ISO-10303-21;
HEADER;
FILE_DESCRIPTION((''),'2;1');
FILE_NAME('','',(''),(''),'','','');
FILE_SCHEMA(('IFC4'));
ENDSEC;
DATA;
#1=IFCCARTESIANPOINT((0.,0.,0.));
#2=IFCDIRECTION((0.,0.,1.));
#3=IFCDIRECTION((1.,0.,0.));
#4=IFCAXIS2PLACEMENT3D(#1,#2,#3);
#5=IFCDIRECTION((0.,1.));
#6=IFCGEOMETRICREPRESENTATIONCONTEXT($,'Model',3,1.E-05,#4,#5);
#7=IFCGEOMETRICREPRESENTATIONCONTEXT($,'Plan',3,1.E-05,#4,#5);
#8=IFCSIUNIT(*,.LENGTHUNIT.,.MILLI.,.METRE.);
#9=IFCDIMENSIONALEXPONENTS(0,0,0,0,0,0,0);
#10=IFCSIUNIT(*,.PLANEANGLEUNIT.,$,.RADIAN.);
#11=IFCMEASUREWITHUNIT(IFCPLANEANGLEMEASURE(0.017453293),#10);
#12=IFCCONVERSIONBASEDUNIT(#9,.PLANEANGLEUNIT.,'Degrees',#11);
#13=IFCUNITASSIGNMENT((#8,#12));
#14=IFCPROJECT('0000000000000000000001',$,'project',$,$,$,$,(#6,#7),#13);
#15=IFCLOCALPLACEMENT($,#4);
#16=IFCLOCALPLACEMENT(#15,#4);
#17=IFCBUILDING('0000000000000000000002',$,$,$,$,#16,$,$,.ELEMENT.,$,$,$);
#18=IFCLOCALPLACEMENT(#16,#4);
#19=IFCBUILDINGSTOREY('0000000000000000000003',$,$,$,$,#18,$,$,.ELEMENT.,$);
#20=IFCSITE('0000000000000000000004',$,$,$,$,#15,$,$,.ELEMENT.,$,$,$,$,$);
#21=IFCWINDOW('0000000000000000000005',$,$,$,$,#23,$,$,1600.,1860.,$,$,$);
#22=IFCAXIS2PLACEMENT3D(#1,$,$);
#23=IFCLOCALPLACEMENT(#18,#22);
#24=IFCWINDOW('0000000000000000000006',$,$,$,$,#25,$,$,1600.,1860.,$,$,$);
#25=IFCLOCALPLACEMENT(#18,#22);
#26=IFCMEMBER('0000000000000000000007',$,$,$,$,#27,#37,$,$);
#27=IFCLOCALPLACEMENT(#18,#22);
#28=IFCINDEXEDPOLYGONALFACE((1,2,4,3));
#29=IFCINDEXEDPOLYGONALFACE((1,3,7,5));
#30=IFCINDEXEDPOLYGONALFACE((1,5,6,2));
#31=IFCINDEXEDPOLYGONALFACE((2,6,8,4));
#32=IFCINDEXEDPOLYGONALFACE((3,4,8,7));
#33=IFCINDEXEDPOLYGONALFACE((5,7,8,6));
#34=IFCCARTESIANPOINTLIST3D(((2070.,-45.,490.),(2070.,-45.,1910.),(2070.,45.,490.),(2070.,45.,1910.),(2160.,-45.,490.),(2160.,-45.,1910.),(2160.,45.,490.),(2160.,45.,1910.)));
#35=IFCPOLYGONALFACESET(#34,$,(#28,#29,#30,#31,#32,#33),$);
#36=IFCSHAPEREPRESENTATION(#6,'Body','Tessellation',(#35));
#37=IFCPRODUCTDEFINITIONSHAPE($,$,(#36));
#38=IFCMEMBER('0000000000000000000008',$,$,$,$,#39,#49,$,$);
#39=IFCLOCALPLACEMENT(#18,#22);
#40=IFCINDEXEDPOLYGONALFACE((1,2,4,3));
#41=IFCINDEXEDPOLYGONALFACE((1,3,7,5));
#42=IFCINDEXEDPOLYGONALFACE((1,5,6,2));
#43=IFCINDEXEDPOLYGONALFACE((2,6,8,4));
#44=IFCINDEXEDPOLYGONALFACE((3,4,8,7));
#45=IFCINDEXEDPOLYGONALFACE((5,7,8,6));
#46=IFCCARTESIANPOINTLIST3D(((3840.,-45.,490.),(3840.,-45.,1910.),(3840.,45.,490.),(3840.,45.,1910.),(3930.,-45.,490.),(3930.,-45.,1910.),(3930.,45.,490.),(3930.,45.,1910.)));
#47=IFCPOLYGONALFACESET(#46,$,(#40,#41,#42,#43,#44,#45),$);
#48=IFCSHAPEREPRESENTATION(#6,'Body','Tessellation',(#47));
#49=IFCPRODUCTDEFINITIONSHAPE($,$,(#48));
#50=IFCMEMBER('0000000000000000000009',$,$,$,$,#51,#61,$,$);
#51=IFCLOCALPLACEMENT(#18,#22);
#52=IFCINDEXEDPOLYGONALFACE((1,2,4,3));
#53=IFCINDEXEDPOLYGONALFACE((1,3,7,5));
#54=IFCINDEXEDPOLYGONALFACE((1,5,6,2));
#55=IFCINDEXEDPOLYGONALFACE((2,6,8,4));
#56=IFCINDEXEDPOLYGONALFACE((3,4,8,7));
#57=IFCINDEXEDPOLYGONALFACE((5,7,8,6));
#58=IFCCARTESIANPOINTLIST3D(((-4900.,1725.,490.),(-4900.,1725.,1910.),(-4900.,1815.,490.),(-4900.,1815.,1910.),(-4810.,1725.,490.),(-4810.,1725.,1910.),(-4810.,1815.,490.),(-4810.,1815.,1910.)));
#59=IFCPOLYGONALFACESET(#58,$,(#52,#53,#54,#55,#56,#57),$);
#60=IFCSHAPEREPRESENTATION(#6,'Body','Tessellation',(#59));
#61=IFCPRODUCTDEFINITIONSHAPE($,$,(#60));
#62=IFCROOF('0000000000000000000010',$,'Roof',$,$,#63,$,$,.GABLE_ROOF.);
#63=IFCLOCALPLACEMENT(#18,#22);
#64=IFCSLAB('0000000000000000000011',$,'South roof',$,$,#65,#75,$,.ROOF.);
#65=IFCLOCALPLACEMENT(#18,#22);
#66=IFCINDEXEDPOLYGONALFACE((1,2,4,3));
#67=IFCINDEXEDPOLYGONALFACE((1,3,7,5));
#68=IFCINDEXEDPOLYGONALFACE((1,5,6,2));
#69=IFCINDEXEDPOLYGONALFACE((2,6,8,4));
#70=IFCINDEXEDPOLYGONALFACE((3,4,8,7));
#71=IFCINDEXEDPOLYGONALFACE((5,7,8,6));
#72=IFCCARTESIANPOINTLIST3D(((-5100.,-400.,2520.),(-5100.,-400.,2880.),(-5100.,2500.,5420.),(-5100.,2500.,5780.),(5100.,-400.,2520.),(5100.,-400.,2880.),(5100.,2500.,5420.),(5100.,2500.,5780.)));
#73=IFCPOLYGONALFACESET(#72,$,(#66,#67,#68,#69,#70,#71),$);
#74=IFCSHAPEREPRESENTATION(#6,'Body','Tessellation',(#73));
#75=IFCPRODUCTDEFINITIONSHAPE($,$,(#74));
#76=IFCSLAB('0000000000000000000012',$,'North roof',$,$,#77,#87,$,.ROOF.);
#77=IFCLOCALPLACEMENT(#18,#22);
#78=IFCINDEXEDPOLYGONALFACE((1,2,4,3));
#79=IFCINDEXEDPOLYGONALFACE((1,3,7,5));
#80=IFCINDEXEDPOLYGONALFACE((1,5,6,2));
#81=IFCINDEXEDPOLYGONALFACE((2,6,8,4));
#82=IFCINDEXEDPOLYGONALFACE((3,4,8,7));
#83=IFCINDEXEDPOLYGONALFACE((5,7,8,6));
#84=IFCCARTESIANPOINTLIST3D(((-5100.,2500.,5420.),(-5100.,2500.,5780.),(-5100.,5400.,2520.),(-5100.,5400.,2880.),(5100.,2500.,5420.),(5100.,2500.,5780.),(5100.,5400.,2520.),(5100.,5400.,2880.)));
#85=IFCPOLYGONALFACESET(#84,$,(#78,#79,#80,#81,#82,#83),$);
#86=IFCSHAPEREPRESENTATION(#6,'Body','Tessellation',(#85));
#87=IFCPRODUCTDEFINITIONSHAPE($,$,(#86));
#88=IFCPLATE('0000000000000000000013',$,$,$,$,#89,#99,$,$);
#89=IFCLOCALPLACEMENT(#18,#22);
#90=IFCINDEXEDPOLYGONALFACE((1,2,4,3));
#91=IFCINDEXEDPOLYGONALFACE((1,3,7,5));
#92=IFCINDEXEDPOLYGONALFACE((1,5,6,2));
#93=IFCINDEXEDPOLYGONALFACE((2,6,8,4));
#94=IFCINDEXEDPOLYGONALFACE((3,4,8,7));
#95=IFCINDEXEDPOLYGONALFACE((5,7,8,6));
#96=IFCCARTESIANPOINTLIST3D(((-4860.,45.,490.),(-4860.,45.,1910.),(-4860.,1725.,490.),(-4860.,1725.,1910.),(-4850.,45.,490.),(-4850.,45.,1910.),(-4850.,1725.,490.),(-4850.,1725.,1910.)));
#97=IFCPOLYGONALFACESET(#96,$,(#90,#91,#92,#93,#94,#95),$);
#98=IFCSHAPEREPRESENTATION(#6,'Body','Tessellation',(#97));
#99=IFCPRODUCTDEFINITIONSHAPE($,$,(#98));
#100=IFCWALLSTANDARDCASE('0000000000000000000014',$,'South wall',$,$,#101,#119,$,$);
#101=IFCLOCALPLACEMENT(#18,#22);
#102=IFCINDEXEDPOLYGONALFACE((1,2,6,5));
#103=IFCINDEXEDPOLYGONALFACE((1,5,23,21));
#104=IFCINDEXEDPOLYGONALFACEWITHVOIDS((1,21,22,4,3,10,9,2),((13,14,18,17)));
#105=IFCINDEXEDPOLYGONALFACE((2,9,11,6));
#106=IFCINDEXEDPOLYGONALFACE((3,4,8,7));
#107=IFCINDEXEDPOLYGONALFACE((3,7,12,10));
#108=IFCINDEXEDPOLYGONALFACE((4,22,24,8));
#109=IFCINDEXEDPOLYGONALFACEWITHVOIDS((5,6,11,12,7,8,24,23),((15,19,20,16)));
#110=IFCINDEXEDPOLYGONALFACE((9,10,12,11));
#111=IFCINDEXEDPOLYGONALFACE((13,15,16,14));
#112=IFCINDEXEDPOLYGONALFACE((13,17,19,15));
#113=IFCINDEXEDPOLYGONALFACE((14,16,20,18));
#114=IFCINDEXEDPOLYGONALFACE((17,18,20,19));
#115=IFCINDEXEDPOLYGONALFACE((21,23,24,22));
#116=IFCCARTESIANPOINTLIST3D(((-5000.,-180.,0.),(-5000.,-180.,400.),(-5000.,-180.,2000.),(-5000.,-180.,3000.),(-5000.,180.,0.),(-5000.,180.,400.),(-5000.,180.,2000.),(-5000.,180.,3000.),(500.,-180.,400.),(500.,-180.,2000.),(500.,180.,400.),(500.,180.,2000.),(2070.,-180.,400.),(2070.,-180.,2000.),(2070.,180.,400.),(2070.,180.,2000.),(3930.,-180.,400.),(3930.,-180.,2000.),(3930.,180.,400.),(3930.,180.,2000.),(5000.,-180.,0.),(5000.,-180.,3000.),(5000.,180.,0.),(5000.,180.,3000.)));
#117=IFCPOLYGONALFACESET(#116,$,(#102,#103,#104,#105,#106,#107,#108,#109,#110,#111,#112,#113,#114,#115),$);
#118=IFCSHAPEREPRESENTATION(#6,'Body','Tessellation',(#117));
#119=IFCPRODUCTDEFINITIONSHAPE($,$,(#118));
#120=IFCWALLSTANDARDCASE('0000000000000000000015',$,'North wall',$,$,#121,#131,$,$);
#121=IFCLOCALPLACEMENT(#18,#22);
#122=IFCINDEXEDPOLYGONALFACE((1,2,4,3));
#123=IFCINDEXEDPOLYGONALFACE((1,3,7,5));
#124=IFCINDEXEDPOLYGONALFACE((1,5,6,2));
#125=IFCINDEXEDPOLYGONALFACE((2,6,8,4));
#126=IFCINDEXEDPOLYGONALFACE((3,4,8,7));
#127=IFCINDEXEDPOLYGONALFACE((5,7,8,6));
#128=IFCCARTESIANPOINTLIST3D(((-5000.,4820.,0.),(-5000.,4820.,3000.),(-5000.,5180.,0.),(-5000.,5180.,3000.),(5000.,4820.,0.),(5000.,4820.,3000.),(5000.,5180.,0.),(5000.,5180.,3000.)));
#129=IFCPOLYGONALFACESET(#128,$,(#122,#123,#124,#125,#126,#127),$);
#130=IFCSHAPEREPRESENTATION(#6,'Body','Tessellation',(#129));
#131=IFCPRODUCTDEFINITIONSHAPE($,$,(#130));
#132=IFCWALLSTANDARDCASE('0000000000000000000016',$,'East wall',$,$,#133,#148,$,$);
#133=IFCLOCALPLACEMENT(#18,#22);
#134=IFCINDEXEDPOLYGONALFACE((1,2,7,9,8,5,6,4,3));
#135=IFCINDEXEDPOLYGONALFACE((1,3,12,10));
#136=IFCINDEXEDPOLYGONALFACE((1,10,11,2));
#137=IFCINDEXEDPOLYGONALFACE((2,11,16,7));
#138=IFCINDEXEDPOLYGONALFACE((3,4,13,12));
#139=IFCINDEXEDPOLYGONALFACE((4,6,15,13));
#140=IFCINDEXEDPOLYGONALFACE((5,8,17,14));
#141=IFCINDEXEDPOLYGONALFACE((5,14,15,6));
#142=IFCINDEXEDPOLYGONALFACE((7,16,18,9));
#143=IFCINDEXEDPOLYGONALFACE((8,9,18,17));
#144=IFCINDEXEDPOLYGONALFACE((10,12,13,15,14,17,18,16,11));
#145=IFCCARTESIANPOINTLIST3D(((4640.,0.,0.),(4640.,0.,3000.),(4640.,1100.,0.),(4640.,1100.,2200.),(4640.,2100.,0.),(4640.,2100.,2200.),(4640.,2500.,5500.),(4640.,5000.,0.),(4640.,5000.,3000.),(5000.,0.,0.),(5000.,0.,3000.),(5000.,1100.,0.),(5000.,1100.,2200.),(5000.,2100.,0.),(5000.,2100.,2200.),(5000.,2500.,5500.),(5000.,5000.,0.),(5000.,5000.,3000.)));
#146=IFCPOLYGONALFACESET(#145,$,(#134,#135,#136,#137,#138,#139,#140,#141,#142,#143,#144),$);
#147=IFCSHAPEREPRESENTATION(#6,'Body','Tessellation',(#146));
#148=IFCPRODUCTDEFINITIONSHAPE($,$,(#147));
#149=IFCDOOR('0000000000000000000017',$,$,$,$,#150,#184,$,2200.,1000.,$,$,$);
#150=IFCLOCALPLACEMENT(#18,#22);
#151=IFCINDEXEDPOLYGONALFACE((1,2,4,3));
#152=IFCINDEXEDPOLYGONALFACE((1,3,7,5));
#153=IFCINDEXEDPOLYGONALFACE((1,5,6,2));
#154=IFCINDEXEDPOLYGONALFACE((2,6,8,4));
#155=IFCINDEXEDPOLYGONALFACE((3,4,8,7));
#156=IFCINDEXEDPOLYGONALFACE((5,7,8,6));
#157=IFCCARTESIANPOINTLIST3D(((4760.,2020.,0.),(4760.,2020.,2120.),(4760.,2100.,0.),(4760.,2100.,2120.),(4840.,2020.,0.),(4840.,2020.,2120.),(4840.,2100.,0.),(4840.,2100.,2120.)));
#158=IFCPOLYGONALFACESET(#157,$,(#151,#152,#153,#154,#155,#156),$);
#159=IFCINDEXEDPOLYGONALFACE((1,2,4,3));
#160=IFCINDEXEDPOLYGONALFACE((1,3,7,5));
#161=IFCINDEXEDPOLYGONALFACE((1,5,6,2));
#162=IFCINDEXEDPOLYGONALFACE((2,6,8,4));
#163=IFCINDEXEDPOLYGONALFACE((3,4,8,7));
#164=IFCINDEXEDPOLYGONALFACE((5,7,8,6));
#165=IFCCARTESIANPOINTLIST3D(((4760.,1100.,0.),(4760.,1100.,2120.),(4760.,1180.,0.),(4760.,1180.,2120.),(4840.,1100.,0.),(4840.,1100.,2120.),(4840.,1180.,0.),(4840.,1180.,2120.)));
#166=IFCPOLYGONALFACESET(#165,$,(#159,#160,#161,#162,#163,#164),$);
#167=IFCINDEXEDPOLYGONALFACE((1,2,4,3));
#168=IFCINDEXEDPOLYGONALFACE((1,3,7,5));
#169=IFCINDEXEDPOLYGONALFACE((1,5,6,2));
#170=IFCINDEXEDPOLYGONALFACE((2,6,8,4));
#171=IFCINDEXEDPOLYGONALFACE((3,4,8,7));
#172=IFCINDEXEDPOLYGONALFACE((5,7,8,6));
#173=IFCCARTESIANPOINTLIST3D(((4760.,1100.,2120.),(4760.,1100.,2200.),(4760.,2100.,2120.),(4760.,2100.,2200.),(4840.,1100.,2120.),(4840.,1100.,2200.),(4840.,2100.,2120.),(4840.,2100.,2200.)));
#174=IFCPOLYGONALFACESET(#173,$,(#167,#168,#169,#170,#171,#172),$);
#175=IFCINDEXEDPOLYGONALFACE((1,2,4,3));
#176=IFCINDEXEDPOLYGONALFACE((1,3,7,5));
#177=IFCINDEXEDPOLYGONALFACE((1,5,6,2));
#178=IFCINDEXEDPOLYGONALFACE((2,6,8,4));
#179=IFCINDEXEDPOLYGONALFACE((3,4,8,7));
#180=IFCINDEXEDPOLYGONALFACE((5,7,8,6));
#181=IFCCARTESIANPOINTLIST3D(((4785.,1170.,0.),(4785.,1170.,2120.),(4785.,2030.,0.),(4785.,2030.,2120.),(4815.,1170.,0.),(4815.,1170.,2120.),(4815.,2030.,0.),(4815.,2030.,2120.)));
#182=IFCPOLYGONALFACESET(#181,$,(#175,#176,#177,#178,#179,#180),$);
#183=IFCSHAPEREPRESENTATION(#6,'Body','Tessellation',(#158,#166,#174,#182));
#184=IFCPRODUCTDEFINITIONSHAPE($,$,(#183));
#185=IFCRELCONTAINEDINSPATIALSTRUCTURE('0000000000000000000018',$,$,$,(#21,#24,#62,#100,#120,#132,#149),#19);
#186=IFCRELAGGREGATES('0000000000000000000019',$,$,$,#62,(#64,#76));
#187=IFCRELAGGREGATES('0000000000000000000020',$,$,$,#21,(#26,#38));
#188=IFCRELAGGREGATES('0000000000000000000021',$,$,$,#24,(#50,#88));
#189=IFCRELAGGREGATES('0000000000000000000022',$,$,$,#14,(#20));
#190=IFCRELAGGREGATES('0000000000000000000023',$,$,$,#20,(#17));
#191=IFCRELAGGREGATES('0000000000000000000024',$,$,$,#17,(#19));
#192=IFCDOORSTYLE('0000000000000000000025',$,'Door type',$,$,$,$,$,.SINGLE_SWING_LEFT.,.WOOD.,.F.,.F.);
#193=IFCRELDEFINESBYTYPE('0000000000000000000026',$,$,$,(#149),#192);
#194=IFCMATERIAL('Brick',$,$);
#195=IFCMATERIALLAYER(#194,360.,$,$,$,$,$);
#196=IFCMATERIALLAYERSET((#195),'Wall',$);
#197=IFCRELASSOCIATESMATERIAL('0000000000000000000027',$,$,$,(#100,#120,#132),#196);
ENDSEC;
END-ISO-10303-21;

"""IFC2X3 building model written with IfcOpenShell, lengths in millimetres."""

from ifc_helpers import new_model, entity, si_unit, converted_unit, direction, frame, origin_with_axes, place, context, project, spatial, polyline, outline, extrude, clip, halfspace, source, transform, mapped, material, layer, layer_set, layer_usage, type_object, element, fill, aggregate, save


model = new_model("IFC2X3")

# Units and contexts
model_context = context("Model", 3, precision=1e-05, world=origin_with_axes(), true_north=direction((0.0, 1.0)))
plan_context = context("Plan", 3, precision=1e-05, world=origin_with_axes(), true_north=direction((0.0, 1.0)))
ifc_project = project(units=[si_unit("LENGTHUNIT", "METRE", prefix="MILLI"), converted_unit("PLANEANGLEUNIT", "Degrees", entity("IfcPlaneAngleMeasure", 0.017453293), si_unit("PLANEANGLEUNIT", "RADIAN"), dimensions=[0, 0, 0, 0, 0, 0, 0])], contexts=[model_context, plan_context])

# Site, building, storey
site_placement = place(None, origin_with_axes())
site = spatial("IfcSite", under=ifc_project, at=site_placement, CompositionType="ELEMENT")
building_placement = place(site_placement, origin_with_axes())
building = spatial("IfcBuilding", under=site, at=building_placement, CompositionType="ELEMENT")
storey_placement = place(building_placement, origin_with_axes())
storey = spatial("IfcBuildingStorey", under=building, at=storey_placement, CompositionType="ELEMENT")

# Windows
window_1_placement = place(storey_placement, frame((2070.0, -45.0, 400.0), z_axis=(0.0, 0.0, 1.0), x_axis=(1.0, 0.0, 0.0)))
window_1 = element("IfcWindow", 1, at=window_1_placement, inside=storey, OverallHeight=1600.0, OverallWidth=1860.0)
window_2_placement = place(storey_placement, frame((-4810.0, -45.0, 400.0), z_axis=(0.0, 0.0, 1.0), x_axis=(0.0, 1.0, 0.0)))
window_2 = element("IfcWindow", 2, at=window_2_placement, inside=storey, OverallHeight=1600.0, OverallWidth=1860.0)

# Members
shared_shape_1 = source(origin_with_axes(), model_context, "Body", "SweptSolid", [
    extrude(outline(polyline([(-45.0, -45.0), (45.0, -45.0), (45.0, 45.0), (-45.0, 45.0), (-45.0, -45.0)])), origin_with_axes(), (0.0, 0.0, 1.0), 1420.0),
])
member_1_placement = place(window_1_placement, frame((45.0, 45.0, 90.0), z_axis=(0.0, 0.0, 1.0), x_axis=(1.0, 0.0, 0.0)))
member_1 = element("IfcMember", 3, at=member_1_placement, context=model_context, shape_type="MappedRepresentation", body=[
    mapped(shared_shape_1, transform((0.0, 0.0, 0.0))),
])
member_2_placement = place(window_1_placement, frame((1815.0, 45.0, 90.0), z_axis=(0.0, 0.0, 1.0), x_axis=(1.0, 0.0, 0.0)))
member_2 = element("IfcMember", 4, at=member_2_placement, context=model_context, shape_type="MappedRepresentation", body=[
    mapped(shared_shape_1, transform((0.0, 0.0, 0.0))),
])
member_3_placement = place(window_2_placement, frame((1815.0, 45.0, 90.0), z_axis=(0.0, 0.0, 1.0), x_axis=(1.0, 0.0, 0.0)))
member_3 = element("IfcMember", 5, at=member_3_placement, context=model_context, shape_type="MappedRepresentation", body=[
    mapped(shared_shape_1, transform((0.0, 0.0, 0.0))),
])

# Roof, slabs
roof_placement = place(storey_placement, origin_with_axes())
roof = element("IfcRoof", 6, at=roof_placement, inside=storey, Name="Roof", ShapeType="GABLE_ROOF")
shared_shape_2 = source(origin_with_axes(), model_context, "Body", "SweptSolid", [
    extrude(outline(polyline([(-5100.0, -180.0), (5100.0, -180.0), (5100.0, 180.0), (-5100.0, 180.0), (-5100.0, -180.0)])), frame((0.0, 0.0, 0.0), z_axis=(0.0, 1.0, 0.0), x_axis=(1.0, 0.0, 0.0)), (0.0, -0.707107, 0.707107), 4101.2),
])
slab_1_placement = place(roof_placement, frame((0.0, -400.0, 2700.0), z_axis=(0.0, 0.0, 1.0), x_axis=(1.0, 0.0, 0.0)))
slab_1 = element("IfcSlab", 7, at=slab_1_placement, Name="South roof", PredefinedType="ROOF", context=model_context, shape_type="MappedRepresentation", body=[
    mapped(shared_shape_2, transform((0.0, 0.0, 0.0))),
])
slab_2_placement = place(roof_placement, frame((0.0, 5400.0, 2700.0), z_axis=(0.0, 0.0, 1.0), x_axis=(-1.0, 0.0, 0.0)))
slab_2 = element("IfcSlab", 8, at=slab_2_placement, Name="North roof", PredefinedType="ROOF", context=model_context, shape_type="MappedRepresentation", body=[
    mapped(shared_shape_2, transform((0.0, 0.0, 0.0))),
])
aggregate(roof, [slab_1, slab_2])

# Plate
aggregate(window_1, [member_1, member_2])
plate_1_placement = place(window_2_placement, frame((930.0, 45.0, 90.0), z_axis=(0.0, 0.0, 1.0), x_axis=(1.0, 0.0, 0.0)))
plate_1 = element("IfcPlate", 9, at=plate_1_placement, context=model_context, shape_type="SweptSolid", body=[
    extrude(outline(polyline([(-840.0, -5.0), (840.0, -5.0), (840.0, 5.0), (-840.0, 5.0), (-840.0, -5.0)])), origin_with_axes(), (0.0, 0.0, 1.0), 1420.0),
])
aggregate(window_2, [member_3, plate_1])

# Wall, openings
ifc_material = material(Name="Brick")
ifc_layer = layer(ifc_material, 360.0)
ifc_layer_set = layer_set([ifc_layer], Name="Wall")
ifc_layer_usage = layer_usage(ifc_layer_set, "AXIS2", "POSITIVE", -180.0)
wall_1_placement = place(storey_placement, origin_with_axes())
wall_1 = element("IfcWallStandardCase", 10, at=wall_1_placement, inside=storey, material=ifc_layer_usage, Name="South wall", context=model_context, shape_type="SweptSolid", body=[
    extrude(outline(polyline([(-5000.0, -180.0), (5000.0, -180.0), (5000.0, 180.0), (-5000.0, 180.0), (-5000.0, -180.0)])), origin_with_axes(), (0.0, 0.0, 1.0), 3000.0),
])
opening_1_placement = place(wall_1_placement, frame((-2500.0, 0.0, 400.0), z_axis=(0.0, 0.0, 1.0), x_axis=(1.0, 0.0, 0.0)))
element("IfcOpeningElement", 11, at=opening_1_placement, cuts=wall_1, context=model_context, shape_type="SweptSolid", body=[
    extrude(outline(polyline([(-3000.0, -1815.0), (3000.0, -1815.0), (3000.0, 1815.0), (-3000.0, 1815.0), (-3000.0, -1815.0)])), origin_with_axes(), (0.0, 0.0, 1.0), 1600.0),
])
opening_2_placement = place(storey_placement, frame((3000.0, 0.0, 400.0), z_axis=(0.0, 0.0, 1.0), x_axis=(1.0, 0.0, 0.0)))
element("IfcOpeningElement", 12, at=opening_2_placement, cuts=wall_1, context=model_context, shape_type="SweptSolid", body=[
    extrude(outline(polyline([(-930.0, -1500.0), (930.0, -1500.0), (930.0, 1500.0), (-930.0, 1500.0), (-930.0, -1500.0)])), origin_with_axes(), (0.0, 0.0, 1.0), 1600.0),
])

# Wall
wall_2_placement = place(storey_placement, frame((0.0, 5000.0, 0.0), z_axis=(0.0, 0.0, 1.0), x_axis=(1.0, 0.0, 0.0)))
element("IfcWallStandardCase", 13, at=wall_2_placement, inside=storey, material=ifc_layer_usage, Name="North wall", context=model_context, shape_type="SweptSolid", body=[
    extrude(outline(polyline([(-5000.0, -180.0), (5000.0, -180.0), (5000.0, 180.0), (-5000.0, 180.0), (-5000.0, -180.0)])), origin_with_axes(), (0.0, 0.0, 1.0), 3000.0),
])

# Wall, opening, door
wall_3_placement = place(storey_placement, frame((4820.0, 2500.0, 0.0), z_axis=(0.0, 0.0, 1.0), x_axis=(0.0, 1.0, 0.0)))
wall_3 = element("IfcWallStandardCase", 14, at=wall_3_placement, inside=storey, material=ifc_layer_usage, Name="East wall", context=model_context, shape_type="Clipping", body=[
    clip(clip(extrude(outline(polyline([(-2500.0, -180.0), (2500.0, -180.0), (2500.0, 180.0), (-2500.0, 180.0), (-2500.0, -180.0)])), origin_with_axes(), (0.0, 0.0, 1.0), 6000.0), halfspace(frame((-2500.0, 0.0, 3000.0), z_axis=(-1.0, 0.0, 1.0), x_axis=(1.0, 0.0, 0.0)), False)), halfspace(frame((2500.0, 0.0, 3000.0), z_axis=(1.0, 0.0, 1.0), x_axis=(1.0, 0.0, 0.0)), False)),
])
opening_3_placement = place(storey_placement, frame((4820.0, 1600.0, 0.0), z_axis=(0.0, 0.0, 1.0), x_axis=(1.0, 0.0, 0.0)))
opening_3 = element("IfcOpeningElement", 15, at=opening_3_placement, cuts=wall_3, context=model_context, shape_type="SweptSolid", body=[
    extrude(outline(polyline([(-500.0, -500.0), (500.0, -500.0), (500.0, 500.0), (-500.0, 500.0), (-500.0, -500.0)])), origin_with_axes(), (0.0, 0.0, 1.0), 2200.0),
])
door_style = type_object("IfcDoorStyle", Name="Door type", ConstructionType="WOOD", OperationType="SINGLE_SWING_LEFT", ParameterTakesPrecedence=False, Sizeable=False)
door_placement = place(storey_placement, frame((4800.0, 1600.0, 0.0), z_axis=(0.0, 0.0, 1.0), x_axis=(0.0, 1.0, 0.0)))
door = element("IfcDoor", 16, at=door_placement, inside=storey, type_object=door_style, OverallHeight=2200.0, OverallWidth=1000.0, context=model_context, shape_type="SweptSolid", body=[
    extrude(outline(polyline([(-40.0, -40.0), (40.0, -40.0), (40.0, 40.0), (-40.0, 40.0), (-40.0, -40.0)])), frame((460.0, 0.0, 0.0), z_axis=(0.0, 0.0, 1.0), x_axis=(1.0, 0.0, 0.0)), (0.0, 0.0, 1.0), 2120.0),
    extrude(outline(polyline([(-40.0, -40.0), (40.0, -40.0), (40.0, 40.0), (-40.0, 40.0), (-40.0, -40.0)])), frame((-460.0, 0.0, 0.0), z_axis=(0.0, 0.0, 1.0), x_axis=(1.0, 0.0, 0.0)), (0.0, 0.0, 1.0), 2120.0),
    extrude(outline(polyline([(-500.0, -40.0), (500.0, -40.0), (500.0, 40.0), (-500.0, 40.0), (-500.0, -40.0)])), frame((0.0, 0.0, 2120.0), z_axis=(0.0, 0.0, 1.0), x_axis=(1.0, 0.0, 0.0)), (0.0, 0.0, 1.0), 80.0),
    extrude(outline(polyline([(-430.0, -15.0), (430.0, -15.0), (430.0, 15.0), (-430.0, 15.0), (-430.0, -15.0)])), origin_with_axes(), (0.0, 0.0, 1.0), 2120.0),
])
fill(opening_3, door)

save(model, "model.ifc")
